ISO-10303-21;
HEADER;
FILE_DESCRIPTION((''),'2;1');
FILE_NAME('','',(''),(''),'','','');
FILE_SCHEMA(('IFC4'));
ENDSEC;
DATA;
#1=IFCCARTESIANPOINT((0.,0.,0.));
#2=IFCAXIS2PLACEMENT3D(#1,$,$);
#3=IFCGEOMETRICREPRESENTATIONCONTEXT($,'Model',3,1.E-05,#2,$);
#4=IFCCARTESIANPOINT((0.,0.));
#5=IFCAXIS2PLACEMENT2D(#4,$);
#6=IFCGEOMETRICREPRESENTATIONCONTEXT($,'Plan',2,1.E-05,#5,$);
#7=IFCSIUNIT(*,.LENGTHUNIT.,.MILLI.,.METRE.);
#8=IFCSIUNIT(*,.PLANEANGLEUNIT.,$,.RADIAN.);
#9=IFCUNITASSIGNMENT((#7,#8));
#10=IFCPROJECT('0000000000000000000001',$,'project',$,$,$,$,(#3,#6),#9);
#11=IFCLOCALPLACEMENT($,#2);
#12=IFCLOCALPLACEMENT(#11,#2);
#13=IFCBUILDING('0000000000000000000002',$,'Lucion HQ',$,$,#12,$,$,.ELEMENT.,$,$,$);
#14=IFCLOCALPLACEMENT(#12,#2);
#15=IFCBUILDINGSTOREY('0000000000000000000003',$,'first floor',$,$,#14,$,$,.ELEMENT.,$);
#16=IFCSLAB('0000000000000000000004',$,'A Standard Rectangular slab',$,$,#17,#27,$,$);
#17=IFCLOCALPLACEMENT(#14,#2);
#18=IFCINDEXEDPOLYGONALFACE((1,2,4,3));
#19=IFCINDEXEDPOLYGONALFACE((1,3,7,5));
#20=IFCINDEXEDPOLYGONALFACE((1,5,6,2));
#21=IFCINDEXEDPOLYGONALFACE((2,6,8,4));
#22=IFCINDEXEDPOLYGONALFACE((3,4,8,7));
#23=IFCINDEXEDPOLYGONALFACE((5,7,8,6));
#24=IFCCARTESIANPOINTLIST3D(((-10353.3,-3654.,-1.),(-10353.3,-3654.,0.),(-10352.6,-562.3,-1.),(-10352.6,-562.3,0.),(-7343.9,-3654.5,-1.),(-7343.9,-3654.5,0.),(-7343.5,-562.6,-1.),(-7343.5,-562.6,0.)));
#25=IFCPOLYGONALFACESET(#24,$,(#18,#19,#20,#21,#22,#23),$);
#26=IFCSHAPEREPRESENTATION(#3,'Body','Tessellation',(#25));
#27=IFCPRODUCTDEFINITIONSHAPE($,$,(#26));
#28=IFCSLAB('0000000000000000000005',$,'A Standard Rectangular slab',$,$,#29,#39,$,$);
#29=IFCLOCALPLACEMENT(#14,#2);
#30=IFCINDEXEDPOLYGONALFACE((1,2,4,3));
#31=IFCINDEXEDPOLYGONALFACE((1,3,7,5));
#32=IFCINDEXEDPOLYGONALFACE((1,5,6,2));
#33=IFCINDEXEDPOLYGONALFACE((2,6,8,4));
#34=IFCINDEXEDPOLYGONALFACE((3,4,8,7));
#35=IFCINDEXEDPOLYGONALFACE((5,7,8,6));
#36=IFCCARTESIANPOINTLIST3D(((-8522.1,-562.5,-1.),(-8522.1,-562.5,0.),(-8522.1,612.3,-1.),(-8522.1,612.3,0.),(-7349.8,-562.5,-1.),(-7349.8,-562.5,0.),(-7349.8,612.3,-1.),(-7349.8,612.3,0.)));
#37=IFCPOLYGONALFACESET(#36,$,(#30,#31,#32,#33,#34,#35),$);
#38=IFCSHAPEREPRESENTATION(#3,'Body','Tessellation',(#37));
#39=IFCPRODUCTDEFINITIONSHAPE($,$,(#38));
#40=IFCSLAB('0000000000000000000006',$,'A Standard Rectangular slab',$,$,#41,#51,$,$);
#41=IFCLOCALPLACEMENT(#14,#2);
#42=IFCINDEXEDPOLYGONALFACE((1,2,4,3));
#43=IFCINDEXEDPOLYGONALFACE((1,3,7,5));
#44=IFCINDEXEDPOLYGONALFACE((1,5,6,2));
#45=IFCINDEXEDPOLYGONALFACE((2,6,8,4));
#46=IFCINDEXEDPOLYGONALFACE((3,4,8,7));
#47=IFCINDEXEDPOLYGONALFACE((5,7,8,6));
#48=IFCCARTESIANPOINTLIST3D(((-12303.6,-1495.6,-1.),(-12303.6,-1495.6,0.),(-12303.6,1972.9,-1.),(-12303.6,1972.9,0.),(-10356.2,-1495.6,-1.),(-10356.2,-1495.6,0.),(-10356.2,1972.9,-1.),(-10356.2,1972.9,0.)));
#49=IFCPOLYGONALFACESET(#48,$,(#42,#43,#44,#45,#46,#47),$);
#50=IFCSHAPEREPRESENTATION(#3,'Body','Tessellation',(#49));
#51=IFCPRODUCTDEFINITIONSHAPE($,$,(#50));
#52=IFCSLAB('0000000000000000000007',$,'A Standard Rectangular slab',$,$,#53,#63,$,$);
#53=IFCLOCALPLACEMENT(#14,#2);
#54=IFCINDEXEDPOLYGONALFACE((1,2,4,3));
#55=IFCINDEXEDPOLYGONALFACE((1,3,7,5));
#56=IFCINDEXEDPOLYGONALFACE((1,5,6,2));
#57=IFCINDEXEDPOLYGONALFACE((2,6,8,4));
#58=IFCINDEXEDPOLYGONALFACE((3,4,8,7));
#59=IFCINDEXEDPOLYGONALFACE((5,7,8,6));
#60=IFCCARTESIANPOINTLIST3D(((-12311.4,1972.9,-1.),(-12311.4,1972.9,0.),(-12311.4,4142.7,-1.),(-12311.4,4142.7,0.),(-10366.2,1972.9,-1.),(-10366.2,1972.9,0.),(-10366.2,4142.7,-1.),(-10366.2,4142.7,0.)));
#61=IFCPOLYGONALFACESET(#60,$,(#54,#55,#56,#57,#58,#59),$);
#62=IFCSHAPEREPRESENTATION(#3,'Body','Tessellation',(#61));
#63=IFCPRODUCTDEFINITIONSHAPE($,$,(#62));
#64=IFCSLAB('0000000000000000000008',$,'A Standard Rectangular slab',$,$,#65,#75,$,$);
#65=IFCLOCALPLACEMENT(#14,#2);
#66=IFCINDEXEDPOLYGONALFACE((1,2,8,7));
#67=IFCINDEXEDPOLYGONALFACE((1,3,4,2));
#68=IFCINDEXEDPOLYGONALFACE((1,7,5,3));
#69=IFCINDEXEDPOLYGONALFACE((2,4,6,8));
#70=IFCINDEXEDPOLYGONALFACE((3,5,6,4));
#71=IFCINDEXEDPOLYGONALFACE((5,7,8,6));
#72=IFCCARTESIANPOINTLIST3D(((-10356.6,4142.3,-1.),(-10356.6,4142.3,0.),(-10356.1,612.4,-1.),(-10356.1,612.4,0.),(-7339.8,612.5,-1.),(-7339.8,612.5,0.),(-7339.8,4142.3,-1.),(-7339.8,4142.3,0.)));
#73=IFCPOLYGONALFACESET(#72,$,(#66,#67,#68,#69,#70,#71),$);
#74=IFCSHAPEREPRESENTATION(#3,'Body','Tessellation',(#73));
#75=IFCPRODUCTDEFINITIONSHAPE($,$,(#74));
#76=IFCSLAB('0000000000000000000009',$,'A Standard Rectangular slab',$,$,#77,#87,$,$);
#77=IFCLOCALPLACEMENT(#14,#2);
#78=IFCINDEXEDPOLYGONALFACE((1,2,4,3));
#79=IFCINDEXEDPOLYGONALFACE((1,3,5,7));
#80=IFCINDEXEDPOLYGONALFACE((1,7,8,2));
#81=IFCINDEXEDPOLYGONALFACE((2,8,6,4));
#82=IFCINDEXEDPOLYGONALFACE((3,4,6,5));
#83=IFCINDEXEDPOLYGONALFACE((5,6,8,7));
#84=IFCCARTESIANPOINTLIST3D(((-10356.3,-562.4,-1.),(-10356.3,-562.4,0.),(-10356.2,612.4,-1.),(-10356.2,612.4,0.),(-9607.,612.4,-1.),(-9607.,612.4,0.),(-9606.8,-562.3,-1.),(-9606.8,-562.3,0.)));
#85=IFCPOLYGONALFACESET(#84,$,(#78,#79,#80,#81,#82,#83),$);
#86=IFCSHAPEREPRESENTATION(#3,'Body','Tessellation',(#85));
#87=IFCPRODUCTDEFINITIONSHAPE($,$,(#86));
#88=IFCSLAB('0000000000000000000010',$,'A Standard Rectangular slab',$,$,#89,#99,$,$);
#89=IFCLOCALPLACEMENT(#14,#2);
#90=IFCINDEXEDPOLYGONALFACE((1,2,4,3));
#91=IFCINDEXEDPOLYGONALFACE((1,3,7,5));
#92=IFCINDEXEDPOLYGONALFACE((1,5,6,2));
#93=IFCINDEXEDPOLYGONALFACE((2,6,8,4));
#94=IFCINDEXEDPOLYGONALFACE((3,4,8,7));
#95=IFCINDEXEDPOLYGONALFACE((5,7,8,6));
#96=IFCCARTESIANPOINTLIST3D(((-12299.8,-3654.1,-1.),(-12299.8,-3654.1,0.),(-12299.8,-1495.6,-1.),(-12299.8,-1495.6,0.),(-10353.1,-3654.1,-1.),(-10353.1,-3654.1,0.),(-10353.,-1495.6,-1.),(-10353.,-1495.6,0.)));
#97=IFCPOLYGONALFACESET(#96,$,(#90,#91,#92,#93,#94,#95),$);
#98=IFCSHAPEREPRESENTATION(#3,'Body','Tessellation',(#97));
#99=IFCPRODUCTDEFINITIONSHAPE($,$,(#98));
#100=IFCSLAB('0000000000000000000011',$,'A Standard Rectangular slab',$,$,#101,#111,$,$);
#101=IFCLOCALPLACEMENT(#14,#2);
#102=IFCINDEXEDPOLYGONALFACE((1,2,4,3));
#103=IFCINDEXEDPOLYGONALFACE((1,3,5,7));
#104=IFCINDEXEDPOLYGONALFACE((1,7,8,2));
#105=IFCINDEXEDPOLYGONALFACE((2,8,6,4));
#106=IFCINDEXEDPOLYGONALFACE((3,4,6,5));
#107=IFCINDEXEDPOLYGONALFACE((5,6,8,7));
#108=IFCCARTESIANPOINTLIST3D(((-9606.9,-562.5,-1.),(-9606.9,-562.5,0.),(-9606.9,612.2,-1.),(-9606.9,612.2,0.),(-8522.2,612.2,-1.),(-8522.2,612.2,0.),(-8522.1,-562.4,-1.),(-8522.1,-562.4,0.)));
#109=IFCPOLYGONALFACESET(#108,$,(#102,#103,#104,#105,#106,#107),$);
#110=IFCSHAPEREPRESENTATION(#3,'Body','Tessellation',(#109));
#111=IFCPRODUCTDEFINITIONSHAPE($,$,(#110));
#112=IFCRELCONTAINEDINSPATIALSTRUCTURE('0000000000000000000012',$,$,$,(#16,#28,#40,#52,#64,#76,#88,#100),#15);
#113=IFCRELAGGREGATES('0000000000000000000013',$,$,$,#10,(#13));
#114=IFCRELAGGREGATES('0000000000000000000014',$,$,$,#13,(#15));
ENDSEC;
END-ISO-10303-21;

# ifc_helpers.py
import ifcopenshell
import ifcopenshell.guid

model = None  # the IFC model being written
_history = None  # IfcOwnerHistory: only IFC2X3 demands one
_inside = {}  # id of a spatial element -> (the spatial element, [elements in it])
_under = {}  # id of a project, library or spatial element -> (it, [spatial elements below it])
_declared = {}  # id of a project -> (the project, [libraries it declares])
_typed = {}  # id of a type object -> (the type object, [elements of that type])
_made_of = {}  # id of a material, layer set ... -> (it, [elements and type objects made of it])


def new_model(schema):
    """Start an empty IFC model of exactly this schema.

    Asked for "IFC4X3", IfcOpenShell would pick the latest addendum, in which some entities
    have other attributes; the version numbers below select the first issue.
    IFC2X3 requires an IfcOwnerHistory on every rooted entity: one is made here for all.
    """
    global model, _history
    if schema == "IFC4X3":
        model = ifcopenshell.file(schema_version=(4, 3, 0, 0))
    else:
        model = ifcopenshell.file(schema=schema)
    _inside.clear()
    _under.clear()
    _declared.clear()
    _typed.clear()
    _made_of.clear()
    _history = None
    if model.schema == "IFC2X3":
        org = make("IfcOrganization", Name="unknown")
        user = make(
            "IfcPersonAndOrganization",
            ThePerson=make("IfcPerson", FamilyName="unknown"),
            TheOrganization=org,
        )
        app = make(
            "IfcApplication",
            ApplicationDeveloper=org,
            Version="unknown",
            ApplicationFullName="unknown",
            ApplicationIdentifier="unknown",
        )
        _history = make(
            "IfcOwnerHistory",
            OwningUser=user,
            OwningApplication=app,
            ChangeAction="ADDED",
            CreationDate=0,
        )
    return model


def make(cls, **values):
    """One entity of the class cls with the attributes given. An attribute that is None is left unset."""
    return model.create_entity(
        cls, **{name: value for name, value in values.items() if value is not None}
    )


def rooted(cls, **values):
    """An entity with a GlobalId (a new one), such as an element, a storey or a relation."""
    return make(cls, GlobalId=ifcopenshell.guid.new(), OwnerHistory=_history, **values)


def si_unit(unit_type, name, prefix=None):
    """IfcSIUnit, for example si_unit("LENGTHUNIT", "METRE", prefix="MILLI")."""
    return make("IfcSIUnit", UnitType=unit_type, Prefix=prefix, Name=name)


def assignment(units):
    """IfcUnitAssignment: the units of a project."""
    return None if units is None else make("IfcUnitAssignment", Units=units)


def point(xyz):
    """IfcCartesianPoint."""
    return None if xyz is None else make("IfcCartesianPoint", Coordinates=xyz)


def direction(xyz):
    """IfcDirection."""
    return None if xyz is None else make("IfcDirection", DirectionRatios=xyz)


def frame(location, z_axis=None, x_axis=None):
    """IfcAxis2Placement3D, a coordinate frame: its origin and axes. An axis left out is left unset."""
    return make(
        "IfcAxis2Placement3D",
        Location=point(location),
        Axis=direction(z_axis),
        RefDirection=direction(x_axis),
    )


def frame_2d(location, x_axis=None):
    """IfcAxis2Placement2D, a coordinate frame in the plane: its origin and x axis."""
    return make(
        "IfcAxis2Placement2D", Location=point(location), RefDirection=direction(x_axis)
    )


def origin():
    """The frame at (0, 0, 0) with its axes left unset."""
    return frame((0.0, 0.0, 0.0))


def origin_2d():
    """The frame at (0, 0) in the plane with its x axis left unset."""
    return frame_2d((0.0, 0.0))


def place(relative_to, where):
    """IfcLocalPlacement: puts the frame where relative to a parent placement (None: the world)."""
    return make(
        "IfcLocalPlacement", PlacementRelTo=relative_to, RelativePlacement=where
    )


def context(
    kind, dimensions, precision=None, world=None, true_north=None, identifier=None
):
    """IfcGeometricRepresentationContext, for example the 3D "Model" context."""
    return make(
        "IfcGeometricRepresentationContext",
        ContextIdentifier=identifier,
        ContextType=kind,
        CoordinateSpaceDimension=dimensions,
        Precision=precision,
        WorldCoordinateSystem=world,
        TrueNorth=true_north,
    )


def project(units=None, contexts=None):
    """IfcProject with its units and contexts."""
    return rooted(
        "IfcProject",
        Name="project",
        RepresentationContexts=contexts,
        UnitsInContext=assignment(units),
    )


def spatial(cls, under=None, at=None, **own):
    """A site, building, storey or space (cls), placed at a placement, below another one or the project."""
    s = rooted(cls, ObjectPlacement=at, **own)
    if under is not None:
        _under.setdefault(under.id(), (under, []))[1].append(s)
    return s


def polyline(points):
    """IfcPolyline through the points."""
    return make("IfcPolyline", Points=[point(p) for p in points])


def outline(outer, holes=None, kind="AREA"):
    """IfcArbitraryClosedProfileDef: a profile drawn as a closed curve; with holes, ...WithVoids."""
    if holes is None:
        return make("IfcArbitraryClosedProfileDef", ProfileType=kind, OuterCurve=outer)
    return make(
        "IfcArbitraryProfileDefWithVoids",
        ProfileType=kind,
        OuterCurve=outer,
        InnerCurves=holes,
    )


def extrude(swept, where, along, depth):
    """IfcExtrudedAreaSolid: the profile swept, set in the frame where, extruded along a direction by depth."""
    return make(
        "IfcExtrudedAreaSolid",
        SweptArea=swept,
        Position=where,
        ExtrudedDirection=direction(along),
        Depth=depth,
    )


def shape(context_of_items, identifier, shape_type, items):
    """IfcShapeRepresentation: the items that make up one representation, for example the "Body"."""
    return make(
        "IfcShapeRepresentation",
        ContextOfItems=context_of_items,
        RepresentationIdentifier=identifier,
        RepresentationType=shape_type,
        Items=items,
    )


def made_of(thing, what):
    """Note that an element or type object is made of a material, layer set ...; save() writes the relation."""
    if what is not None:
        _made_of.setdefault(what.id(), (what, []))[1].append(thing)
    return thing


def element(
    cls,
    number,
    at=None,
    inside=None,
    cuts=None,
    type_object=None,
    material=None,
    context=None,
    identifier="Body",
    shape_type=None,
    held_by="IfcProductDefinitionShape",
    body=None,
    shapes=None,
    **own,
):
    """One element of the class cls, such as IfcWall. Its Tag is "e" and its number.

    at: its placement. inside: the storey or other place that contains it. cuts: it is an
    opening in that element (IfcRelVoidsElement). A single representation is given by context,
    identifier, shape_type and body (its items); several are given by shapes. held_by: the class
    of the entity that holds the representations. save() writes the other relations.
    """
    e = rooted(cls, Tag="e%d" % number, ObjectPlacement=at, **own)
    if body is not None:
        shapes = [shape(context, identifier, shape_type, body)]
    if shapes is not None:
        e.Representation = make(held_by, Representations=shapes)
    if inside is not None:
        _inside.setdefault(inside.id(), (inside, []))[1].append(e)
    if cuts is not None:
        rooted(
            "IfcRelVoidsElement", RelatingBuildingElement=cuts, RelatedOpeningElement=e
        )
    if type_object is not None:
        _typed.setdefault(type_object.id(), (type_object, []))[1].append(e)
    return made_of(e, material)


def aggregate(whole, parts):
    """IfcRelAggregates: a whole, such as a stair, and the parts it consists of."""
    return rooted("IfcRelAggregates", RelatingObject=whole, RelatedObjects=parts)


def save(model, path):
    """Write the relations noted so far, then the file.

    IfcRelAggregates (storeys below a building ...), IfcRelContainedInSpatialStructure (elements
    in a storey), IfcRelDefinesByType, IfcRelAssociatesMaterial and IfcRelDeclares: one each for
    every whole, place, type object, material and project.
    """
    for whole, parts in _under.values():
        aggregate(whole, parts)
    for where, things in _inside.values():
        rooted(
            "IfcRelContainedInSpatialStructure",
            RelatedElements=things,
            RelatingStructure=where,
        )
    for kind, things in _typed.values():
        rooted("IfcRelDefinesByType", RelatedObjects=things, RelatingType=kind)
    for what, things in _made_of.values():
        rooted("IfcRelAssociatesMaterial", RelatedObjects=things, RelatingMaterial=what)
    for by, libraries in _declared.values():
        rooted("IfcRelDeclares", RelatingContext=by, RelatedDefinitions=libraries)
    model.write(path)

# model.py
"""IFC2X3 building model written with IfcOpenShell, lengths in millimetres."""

from ifc_helpers import new_model, si_unit, frame, origin, origin_2d, place, context, project, spatial, polyline, outline, extrude, element, save


model = new_model("IFC2X3")

# Units and contexts
model_context = context("Model", 3, precision=1e-05, world=origin())
plan_context = context("Plan", 2, precision=1e-05, world=origin_2d())
ifc_project = project(units=[si_unit("LENGTHUNIT", "METRE", prefix="MILLI"), si_unit("PLANEANGLEUNIT", "RADIAN")], contexts=[model_context, plan_context])

# Building, storey
placement_1 = place(None, origin())
building_placement = place(placement_1, origin())
building = spatial("IfcBuilding", under=ifc_project, at=building_placement, Name="Lucion HQ", CompositionType="ELEMENT")
storey_placement = place(building_placement, origin())
storey = spatial("IfcBuildingStorey", under=building, at=storey_placement, Name="first floor", CompositionType="ELEMENT")

# Slabs
placement_2 = place(None, frame((-8848.4, -2108.4, 0.0)))
slab_1_placement = place(placement_2, origin())
element("IfcSlab", 1, at=slab_1_placement, inside=storey, Name="A Standard Rectangular slab", context=model_context, shape_type="SweptSolid", body=[
    extrude(outline(polyline([(1504.5, -1546.1, 0.0), (-1504.9, -1545.6, 0.0), (-1504.2, 1546.1, 0.0), (1504.9, 1545.8, 0.0), (1504.5, -1546.1, 0.0)]), kind="CURVE"), origin(), (0.0, 0.0, -1.0), 1.0),
])
placement_3 = place(None, frame((-7936.0, 24.9, 0.0)))
slab_2_placement = place(placement_3, origin())
element("IfcSlab", 2, at=slab_2_placement, inside=storey, Name="A Standard Rectangular slab", context=model_context, shape_type="SweptSolid", body=[
    extrude(outline(polyline([(586.2, -587.4, 0.0), (-586.2, -587.4, 0.0), (-586.2, 587.4, 0.0), (586.2, 587.4, 0.0), (586.2, -587.4, 0.0)]), kind="CURVE"), origin(), (0.0, 0.0, -1.0), 1.0),
])
placement_4 = place(None, frame((-11329.9, 238.6, 0.0)))
slab_3_placement = place(placement_4, origin())
element("IfcSlab", 3, at=slab_3_placement, inside=storey, Name="A Standard Rectangular slab", context=model_context, shape_type="SweptSolid", body=[
    extrude(outline(polyline([(973.7, -1734.2, 0.0), (-973.7, -1734.2, 0.0), (-973.7, 1734.2, 0.0), (973.7, 1734.2, 0.0), (973.7, -1734.2, 0.0)]), kind="CURVE"), origin(), (0.0, 0.0, -1.0), 1.0),
])
placement_5 = place(None, frame((-11338.9, 3057.8, 0.0)))
slab_4_placement = place(placement_5, origin())
element("IfcSlab", 4, at=slab_4_placement, inside=storey, Name="A Standard Rectangular slab", context=model_context, shape_type="SweptSolid", body=[
    extrude(outline(polyline([(972.6, -1084.9, 0.0), (-972.6, -1084.9, 0.0), (-972.6, 1084.9, 0.0), (972.6, 1084.9, 0.0), (972.6, -1084.9, 0.0)]), kind="CURVE"), origin(), (0.0, 0.0, -1.0), 1.0),
])
placement_6 = place(None, frame((-8848.2, 2377.4, 0.0)))
slab_5_placement = place(placement_6, origin())
element("IfcSlab", 5, at=slab_5_placement, inside=storey, Name="A Standard Rectangular slab", context=model_context, shape_type="SweptSolid", body=[
    extrude(outline(polyline([(-1507.9, -1765.0, 0.0), (-1508.4, 1765.0, 0.0), (1508.4, 1765.0, 0.0), (1508.4, -1764.9, 0.0), (-1507.9, -1765.0, 0.0)]), kind="CURVE"), origin(), (0.0, 0.0, -1.0), 1.0),
])
placement_7 = place(None, frame((-9981.6, 25.0, 0.0)))
slab_6_placement = place(placement_7, origin())
element("IfcSlab", 6, at=slab_6_placement, inside=storey, Name="A Standard Rectangular slab", context=model_context, shape_type="SweptSolid", body=[
    extrude(outline(polyline([(-374.6, 587.4, 0.0), (374.6, 587.4, 0.0), (374.7, -587.4, 0.0), (-374.7, -587.4, 0.0), (-374.6, 587.4, 0.0)]), kind="CURVE"), origin(), (0.0, 0.0, -1.0), 1.0),
])
placement_8 = place(None, frame((-11326.4, -2574.8, 0.0)))
slab_7_placement = place(placement_8, origin())
element("IfcSlab", 7, at=slab_7_placement, inside=storey, Name="A Standard Rectangular slab", context=model_context, shape_type="SweptSolid", body=[
    extrude(outline(polyline([(973.3, -1079.2, 0.0), (-973.4, -1079.2, 0.0), (-973.4, 1079.2, 0.0), (973.4, 1079.2, 0.0), (973.3, -1079.2, 0.0)]), kind="CURVE"), origin(), (0.0, 0.0, -1.0), 1.0),
])
placement_9 = place(None, frame((-9064.5, 24.9, 0.0)))
slab_8_placement = place(placement_9, origin())
element("IfcSlab", 8, at=slab_8_placement, inside=storey, Name="A Standard Rectangular slab", context=model_context, shape_type="SweptSolid", body=[
    extrude(outline(polyline([(-542.4, 587.4, 0.0), (542.4, 587.3, 0.0), (542.4, -587.3, 0.0), (-542.4, -587.4, 0.0), (-542.4, 587.4, 0.0)]), kind="CURVE"), origin(), (0.0, 0.0, -1.0), 1.0),
])

save(model, "model.ifc")
